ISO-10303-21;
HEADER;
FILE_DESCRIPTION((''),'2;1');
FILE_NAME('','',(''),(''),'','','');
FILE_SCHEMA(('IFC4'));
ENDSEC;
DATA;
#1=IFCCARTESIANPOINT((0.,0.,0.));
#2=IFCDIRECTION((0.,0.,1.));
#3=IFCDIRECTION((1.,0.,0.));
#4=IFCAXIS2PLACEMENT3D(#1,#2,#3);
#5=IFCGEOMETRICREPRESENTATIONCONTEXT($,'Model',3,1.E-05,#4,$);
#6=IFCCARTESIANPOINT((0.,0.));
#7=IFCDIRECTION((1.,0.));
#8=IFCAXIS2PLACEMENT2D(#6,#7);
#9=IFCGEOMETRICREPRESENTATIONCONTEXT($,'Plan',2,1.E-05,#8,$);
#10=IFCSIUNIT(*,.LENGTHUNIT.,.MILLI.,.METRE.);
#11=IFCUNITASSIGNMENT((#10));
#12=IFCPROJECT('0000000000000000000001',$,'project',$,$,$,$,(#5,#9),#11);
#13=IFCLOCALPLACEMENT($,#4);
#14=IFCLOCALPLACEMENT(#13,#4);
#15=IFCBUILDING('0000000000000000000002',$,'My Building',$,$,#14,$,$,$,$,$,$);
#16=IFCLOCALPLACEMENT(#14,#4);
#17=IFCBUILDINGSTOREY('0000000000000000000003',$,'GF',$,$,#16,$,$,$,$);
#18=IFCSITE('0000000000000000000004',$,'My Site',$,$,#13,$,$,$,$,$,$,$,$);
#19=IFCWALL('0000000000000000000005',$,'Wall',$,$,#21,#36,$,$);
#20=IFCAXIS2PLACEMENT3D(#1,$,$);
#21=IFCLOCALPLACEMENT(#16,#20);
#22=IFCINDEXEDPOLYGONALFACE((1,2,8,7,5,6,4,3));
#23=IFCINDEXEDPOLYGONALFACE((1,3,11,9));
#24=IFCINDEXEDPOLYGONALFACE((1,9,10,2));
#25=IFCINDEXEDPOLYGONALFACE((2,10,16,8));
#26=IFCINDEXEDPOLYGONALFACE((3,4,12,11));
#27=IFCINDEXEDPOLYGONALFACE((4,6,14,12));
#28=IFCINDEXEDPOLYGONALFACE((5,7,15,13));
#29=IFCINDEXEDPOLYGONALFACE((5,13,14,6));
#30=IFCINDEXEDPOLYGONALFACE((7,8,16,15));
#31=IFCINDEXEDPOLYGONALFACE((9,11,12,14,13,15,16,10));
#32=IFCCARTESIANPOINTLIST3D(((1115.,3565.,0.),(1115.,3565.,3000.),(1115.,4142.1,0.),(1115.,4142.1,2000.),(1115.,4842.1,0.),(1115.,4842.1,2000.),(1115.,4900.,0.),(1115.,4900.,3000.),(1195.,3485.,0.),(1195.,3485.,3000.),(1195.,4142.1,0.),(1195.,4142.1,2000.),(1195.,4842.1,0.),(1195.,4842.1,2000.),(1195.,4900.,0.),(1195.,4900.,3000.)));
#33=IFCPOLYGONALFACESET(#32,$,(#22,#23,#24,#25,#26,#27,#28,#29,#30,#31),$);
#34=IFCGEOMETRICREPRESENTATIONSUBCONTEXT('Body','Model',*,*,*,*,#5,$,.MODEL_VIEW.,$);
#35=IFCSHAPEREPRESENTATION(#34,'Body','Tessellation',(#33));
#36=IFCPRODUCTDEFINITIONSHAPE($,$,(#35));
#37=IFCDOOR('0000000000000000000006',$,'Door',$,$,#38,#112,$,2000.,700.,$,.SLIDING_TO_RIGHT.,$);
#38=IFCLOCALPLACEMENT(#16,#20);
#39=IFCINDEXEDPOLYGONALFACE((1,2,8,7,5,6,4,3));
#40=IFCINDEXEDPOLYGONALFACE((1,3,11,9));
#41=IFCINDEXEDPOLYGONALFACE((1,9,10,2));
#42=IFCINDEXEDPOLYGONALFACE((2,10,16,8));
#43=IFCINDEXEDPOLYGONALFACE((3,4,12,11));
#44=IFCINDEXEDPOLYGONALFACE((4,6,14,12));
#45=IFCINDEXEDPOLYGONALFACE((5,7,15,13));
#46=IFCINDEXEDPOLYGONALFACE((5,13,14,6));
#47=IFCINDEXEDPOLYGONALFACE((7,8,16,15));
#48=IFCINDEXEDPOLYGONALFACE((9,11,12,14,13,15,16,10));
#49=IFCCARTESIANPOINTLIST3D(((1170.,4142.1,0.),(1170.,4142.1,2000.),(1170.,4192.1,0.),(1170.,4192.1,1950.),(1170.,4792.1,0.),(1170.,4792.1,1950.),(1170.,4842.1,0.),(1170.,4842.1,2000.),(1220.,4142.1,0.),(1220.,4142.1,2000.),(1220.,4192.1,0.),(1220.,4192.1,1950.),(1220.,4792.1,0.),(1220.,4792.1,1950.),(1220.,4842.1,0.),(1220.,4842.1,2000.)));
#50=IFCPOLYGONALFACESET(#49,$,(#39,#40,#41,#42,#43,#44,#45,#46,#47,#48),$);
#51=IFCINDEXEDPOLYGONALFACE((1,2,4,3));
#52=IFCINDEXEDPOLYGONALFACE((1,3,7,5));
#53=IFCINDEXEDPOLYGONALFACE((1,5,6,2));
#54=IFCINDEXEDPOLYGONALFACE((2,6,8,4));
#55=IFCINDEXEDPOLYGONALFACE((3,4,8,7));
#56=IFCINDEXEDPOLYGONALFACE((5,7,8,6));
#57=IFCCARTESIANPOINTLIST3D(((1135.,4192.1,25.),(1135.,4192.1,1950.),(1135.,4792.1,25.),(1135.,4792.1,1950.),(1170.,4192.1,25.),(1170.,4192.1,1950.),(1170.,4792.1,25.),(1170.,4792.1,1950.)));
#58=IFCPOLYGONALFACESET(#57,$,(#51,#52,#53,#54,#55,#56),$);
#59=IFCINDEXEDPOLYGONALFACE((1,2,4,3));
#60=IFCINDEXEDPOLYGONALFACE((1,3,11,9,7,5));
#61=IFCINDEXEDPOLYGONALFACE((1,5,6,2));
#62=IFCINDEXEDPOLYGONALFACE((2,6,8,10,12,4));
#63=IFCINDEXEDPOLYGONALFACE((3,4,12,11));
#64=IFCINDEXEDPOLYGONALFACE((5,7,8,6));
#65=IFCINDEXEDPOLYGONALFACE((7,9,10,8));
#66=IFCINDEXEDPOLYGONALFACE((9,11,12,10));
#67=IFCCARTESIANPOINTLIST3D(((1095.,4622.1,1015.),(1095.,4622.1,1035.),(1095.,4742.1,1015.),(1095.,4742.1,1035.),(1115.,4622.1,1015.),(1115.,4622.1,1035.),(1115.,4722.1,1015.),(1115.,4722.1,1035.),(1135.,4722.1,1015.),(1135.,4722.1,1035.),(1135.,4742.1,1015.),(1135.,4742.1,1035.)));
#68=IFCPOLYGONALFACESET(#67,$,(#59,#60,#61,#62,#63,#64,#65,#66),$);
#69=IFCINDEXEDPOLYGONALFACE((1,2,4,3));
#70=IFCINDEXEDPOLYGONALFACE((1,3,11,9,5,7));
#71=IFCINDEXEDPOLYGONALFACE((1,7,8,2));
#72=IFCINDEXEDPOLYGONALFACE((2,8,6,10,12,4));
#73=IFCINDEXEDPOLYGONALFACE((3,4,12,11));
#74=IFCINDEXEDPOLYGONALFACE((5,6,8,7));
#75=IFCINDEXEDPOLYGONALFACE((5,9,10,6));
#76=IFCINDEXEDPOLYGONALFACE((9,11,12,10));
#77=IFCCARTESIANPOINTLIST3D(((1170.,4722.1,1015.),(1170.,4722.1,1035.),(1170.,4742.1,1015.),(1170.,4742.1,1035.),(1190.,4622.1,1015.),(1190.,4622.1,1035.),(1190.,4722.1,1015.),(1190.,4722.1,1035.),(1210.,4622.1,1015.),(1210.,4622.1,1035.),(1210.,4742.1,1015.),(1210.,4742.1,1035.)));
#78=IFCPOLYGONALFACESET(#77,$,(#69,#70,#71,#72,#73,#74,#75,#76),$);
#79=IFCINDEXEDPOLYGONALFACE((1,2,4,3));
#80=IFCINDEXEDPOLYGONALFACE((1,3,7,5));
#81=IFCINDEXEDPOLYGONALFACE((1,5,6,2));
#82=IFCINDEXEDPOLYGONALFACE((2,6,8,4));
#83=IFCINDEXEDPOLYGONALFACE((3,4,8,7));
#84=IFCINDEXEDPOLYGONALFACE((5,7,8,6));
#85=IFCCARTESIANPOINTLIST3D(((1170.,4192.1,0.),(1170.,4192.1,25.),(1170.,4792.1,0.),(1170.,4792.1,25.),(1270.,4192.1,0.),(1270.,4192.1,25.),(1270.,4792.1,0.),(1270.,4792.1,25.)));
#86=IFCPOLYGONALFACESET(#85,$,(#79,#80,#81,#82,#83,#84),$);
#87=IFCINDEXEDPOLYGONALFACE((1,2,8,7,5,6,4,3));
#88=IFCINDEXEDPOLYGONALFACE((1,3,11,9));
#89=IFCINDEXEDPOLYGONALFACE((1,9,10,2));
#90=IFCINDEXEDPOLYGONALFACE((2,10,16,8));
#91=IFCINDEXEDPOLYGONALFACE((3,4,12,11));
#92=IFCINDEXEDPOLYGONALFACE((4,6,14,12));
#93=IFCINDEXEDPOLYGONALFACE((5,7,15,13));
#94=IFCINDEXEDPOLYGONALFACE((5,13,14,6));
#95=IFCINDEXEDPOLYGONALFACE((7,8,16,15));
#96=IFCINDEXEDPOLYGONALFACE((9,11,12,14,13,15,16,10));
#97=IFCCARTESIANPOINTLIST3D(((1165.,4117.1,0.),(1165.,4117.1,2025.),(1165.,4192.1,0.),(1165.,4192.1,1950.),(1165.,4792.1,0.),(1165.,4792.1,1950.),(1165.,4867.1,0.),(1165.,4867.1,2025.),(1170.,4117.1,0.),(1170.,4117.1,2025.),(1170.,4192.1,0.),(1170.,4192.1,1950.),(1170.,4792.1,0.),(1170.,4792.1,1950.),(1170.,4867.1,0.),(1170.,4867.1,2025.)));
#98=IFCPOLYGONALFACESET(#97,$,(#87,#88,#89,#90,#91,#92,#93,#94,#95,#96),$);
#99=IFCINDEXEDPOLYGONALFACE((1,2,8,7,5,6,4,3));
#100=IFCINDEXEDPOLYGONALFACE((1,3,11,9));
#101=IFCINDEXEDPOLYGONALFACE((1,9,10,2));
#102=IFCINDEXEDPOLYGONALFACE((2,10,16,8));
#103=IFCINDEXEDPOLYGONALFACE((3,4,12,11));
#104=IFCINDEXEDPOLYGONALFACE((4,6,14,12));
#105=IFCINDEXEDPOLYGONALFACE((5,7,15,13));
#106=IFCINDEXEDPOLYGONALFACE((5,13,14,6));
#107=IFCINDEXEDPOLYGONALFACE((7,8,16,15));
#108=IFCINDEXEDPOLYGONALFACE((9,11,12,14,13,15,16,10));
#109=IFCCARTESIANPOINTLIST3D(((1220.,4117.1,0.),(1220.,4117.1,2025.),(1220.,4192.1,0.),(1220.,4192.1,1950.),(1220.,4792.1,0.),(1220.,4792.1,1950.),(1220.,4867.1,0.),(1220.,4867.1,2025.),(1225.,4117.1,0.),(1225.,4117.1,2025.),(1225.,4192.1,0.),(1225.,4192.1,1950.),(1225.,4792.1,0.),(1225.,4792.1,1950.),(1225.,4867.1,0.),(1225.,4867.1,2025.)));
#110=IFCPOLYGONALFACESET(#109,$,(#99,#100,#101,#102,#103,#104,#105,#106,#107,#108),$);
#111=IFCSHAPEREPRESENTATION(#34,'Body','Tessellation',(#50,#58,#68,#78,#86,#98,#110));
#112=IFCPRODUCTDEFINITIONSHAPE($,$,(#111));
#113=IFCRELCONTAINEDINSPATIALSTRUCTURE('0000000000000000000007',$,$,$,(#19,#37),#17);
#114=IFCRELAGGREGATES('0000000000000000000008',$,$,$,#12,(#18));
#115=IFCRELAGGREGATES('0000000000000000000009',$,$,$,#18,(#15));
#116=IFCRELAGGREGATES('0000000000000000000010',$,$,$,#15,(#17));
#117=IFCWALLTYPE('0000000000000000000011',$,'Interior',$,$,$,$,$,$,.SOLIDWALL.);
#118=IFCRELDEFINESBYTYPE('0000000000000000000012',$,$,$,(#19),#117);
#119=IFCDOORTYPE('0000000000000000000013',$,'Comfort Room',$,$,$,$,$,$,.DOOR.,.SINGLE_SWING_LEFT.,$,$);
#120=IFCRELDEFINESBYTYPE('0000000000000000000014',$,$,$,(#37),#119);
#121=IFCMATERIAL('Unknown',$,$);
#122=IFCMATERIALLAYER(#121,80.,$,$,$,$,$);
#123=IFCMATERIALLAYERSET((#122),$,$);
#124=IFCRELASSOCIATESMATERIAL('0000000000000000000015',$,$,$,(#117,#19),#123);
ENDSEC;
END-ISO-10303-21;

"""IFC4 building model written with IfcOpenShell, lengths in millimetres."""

from ifc_helpers import new_model, entity, si_unit, frame, origin_with_axes, origin_2d_with_axis, place, context, subcontext, project, spatial, line, indexed_curve, outline, extrude, shape, source, transform, mapped, material, layer, layer_set, layer_usage, type_object, type_shapes, element, fill, save


model = new_model("IFC4")

# Units and contexts
model_context = context("Model", 3, precision=1e-05, world=origin_with_axes())
plan_context = context("Plan", 2, precision=1e-05, world=origin_2d_with_axis())
body_context_1 = subcontext(model_context, "Body", "Model", "MODEL_VIEW")
body_context_2 = subcontext(plan_context, "Body", "Plan", "PLAN_VIEW")
ifc_project = project(units=[si_unit("LENGTHUNIT", "METRE", prefix="MILLI")], contexts=[model_context, plan_context])

# Site, building, storey
site_placement = place(None, origin_with_axes())
site = spatial("IfcSite", under=ifc_project, at=site_placement, Name="My Site")
building_placement = place(site_placement, origin_with_axes())
building = spatial("IfcBuilding", under=site, at=building_placement, Name="My Building")
storey_placement = place(building_placement, origin_with_axes())
storey = spatial("IfcBuildingStorey", under=building, at=storey_placement, Name="GF")

# Shared definitions
ifc_material = material(Name="Unknown")

# Wall, opening, door
ifc_layer_1 = layer(ifc_material, 80.0)
ifc_layer_set_1 = layer_set([ifc_layer_1])
ifc_layer_usage_1 = layer_usage(ifc_layer_set_1, "AXIS2", "POSITIVE", -100.0)
wall_type_1 = type_object("IfcWallType", Name="Interior", PredefinedType="SOLIDWALL", material=ifc_layer_set_1)
wall_1_placement = place(storey_placement, frame((1215.0, 4900.0, 0.0), z_axis=(0.0, 0.0, 1.0), x_axis=(0.0, -1.0, 0.0)))
wall_1 = element("IfcWall", 1, at=wall_1_placement, inside=storey, type_object=wall_type_1, material=ifc_layer_usage_1, Name="Wall", context=body_context_1, shape_type="SweptSolid", body=[
    extrude(outline(indexed_curve([(0.0, -100.0), (0.0, -20.0), (1415.0, -20.0), (1335.0, -100.0)], segments=[line(1, 2, 3, 4, 1)])), origin_with_axes(), (0.0, 0.0, 1.0), 3000.0),
])
shared_shape_1 = source(origin_with_axes(), body_context_1, "Body", "SweptSolid", [
    extrude(outline(indexed_curve([(0.0, 0.0), (700.0, 0.0), (700.0, 2000.0), (0.0, 2000.0)], segments=[line(1, 2, 3, 4, 1)])), frame((0.0, -600.0, 0.0), z_axis=(0.0, -1.0, 0.0), x_axis=(1.0, 0.0, 0.0)), (0.0, 0.0, -1.0), 1200.0),
])
opening_1_placement = place(wall_1_placement, frame((57.9, -45.0, 0.0), z_axis=(0.0, 0.0, 1.0), x_axis=(1.0, 0.0, 0.0)))
opening_1 = element("IfcOpeningElement", 2, at=opening_1_placement, cuts=wall_1, PredefinedType="OPENING", context=body_context_1, shape_type="MappedRepresentation", body=[
    mapped(shared_shape_1, transform((0.0, 0.0, 0.0), x_axis=(1.0, 0.0, 0.0), y_axis=(0.0, 1.0, 0.0), z_axis=(0.0, 0.0, 1.0), scale=1.0)),
])
door_type_1 = type_object("IfcDoorType", Name="Comfort Room", OperationType="SINGLE_SWING_LEFT", PredefinedType="DOOR")
shared_shape_2 = source(origin_with_axes(), body_context_1, "Body", "SweptSolid", [
    extrude(outline(indexed_curve([(0.0, 0.0), (0.0, 2000.0), (700.0, 2000.0), (700.0, 0.0), (650.0, 0.0), (650.0, 1950.0), (50.0, 1950.0), (50.0, 0.0)], segments=[line(1, 2, 3, 4, 5, 6, 7, 8, 1)])), frame((0.0, 0.0, 0.0), z_axis=(0.0, -1.0, 0.0), x_axis=(1.0, 0.0, 0.0)), (0.0, 0.0, -1.0), 50.0),
    extrude(outline(indexed_curve([(0.0, 0.0), (600.0, 0.0), (600.0, 35.0), (0.0, 35.0)], segments=[line(1, 2, 3, 4, 1)])), frame((50.0, -35.0, 25.0), z_axis=(0.0, 0.0, 1.0), x_axis=(1.0, 0.0, 0.0)), (0.0, 0.0, 1.0), 1925.0),
    extrude(outline(indexed_curve([(0.0, 0.0), (0.0, -40.0), (120.0, -40.0), (120.0, -20.0), (20.0, -20.0), (20.0, 0.0)], segments=[line(1, 2, 3, 4, 5, 6, 1)])), frame((100.0, -35.0, 1015.0), z_axis=(0.0, 0.0, 1.0), x_axis=(1.0, 0.0, 0.0)), (0.0, 0.0, 1.0), 20.0),
    extrude(outline(indexed_curve([(0.0, 0.0), (0.0, 40.0), (120.0, 40.0), (120.0, 20.0), (20.0, 20.0), (20.0, 0.0)], segments=[line(1, 2, 3, 4, 5, 6, 1)])), frame((100.0, 0.0, 1015.0), z_axis=(0.0, 0.0, 1.0), x_axis=(1.0, 0.0, 0.0)), (0.0, 0.0, 1.0), 20.0),
    extrude(outline(indexed_curve([(0.0, 0.0), (600.0, 0.0), (600.0, 100.0), (0.0, 100.0)], segments=[line(1, 2, 3, 4, 1)])), frame((50.0, 0.0, 0.0), z_axis=(0.0, 0.0, 1.0), x_axis=(1.0, 0.0, 0.0)), (0.0, 0.0, 1.0), 25.0),
    extrude(outline(indexed_curve([(0.0, 0.0), (0.0, 2025.0), (750.0, 2025.0), (750.0, 0.0), (675.0, 0.0), (675.0, 1950.0), (75.0, 1950.0), (75.0, 0.0)], segments=[line(1, 2, 3, 4, 5, 6, 7, 8, 1)])), frame((-25.0, -5.0, 0.0), z_axis=(0.0, -1.0, 0.0), x_axis=(1.0, 0.0, 0.0)), (0.0, 0.0, -1.0), 5.0),
    extrude(outline(indexed_curve([(0.0, 0.0), (0.0, 2025.0), (750.0, 2025.0), (750.0, 0.0), (675.0, 0.0), (675.0, 1950.0), (75.0, 1950.0), (75.0, 0.0)], segments=[line(1, 2, 3, 4, 5, 6, 7, 8, 1)])), frame((-25.0, 50.0, 0.0), z_axis=(0.0, -1.0, 0.0), x_axis=(1.0, 0.0, 0.0)), (0.0, 0.0, -1.0), 5.0),
])
shared_shape_3 = source(origin_with_axes(), body_context_2, "Body", "Curve2D", [
    entity("IfcIndexedPolyCurve", entity("IfcCartesianPointList2D", [[0.0, 0.0], [50.0, 0.0], [50.0, 50.0], [0.0, 50.0]]), [entity("IfcLineIndex", [1, 2, 3, 4, 1])]),
    entity("IfcIndexedPolyCurve", entity("IfcCartesianPointList2D", [[700.0, 0.0], [650.0, 0.0], [650.0, 50.0], [700.0, 50.0]]), [entity("IfcLineIndex", [1, 2, 3, 4, 1])]),
    entity("IfcIndexedPolyCurve", entity("IfcCartesianPointList2D", [[950.0, -35.0], [350.0, -35.0], [350.0, 0.0], [950.0, 0.0]]), [entity("IfcLineIndex", [1, 2, 3, 4, 1])]),
])
type_shapes(door_type_1, [shared_shape_2, shared_shape_3])
door_1_placement = place(opening_1_placement, frame((0.0, 0.0, 0.0), z_axis=(0.0, 0.0, 1.0), x_axis=(1.0, 0.0, 0.0)))
door_1 = element("IfcDoor", 3, at=door_1_placement, inside=storey, type_object=door_type_1, Name="Door", OperationType="SLIDING_TO_RIGHT", OverallHeight=2000.0, OverallWidth=700.0, shapes=[
    shape(body_context_1, "Body", "MappedRepresentation", [mapped(shared_shape_2, transform((0.0, 0.0, 0.0), x_axis=(1.0, 0.0, 0.0), y_axis=(0.0, 1.0, 0.0), z_axis=(0.0, 0.0, 1.0), scale=1.0))]),
    shape(body_context_2, "Body", "MappedRepresentation", [mapped(shared_shape_3, transform((0.0, 0.0, 0.0), x_axis=(1.0, 0.0, 0.0), y_axis=(0.0, 1.0, 0.0), z_axis=(0.0, 0.0, 1.0), scale=1.0))]),
])
fill(opening_1, door_1)

save(model, "model.ifc")
